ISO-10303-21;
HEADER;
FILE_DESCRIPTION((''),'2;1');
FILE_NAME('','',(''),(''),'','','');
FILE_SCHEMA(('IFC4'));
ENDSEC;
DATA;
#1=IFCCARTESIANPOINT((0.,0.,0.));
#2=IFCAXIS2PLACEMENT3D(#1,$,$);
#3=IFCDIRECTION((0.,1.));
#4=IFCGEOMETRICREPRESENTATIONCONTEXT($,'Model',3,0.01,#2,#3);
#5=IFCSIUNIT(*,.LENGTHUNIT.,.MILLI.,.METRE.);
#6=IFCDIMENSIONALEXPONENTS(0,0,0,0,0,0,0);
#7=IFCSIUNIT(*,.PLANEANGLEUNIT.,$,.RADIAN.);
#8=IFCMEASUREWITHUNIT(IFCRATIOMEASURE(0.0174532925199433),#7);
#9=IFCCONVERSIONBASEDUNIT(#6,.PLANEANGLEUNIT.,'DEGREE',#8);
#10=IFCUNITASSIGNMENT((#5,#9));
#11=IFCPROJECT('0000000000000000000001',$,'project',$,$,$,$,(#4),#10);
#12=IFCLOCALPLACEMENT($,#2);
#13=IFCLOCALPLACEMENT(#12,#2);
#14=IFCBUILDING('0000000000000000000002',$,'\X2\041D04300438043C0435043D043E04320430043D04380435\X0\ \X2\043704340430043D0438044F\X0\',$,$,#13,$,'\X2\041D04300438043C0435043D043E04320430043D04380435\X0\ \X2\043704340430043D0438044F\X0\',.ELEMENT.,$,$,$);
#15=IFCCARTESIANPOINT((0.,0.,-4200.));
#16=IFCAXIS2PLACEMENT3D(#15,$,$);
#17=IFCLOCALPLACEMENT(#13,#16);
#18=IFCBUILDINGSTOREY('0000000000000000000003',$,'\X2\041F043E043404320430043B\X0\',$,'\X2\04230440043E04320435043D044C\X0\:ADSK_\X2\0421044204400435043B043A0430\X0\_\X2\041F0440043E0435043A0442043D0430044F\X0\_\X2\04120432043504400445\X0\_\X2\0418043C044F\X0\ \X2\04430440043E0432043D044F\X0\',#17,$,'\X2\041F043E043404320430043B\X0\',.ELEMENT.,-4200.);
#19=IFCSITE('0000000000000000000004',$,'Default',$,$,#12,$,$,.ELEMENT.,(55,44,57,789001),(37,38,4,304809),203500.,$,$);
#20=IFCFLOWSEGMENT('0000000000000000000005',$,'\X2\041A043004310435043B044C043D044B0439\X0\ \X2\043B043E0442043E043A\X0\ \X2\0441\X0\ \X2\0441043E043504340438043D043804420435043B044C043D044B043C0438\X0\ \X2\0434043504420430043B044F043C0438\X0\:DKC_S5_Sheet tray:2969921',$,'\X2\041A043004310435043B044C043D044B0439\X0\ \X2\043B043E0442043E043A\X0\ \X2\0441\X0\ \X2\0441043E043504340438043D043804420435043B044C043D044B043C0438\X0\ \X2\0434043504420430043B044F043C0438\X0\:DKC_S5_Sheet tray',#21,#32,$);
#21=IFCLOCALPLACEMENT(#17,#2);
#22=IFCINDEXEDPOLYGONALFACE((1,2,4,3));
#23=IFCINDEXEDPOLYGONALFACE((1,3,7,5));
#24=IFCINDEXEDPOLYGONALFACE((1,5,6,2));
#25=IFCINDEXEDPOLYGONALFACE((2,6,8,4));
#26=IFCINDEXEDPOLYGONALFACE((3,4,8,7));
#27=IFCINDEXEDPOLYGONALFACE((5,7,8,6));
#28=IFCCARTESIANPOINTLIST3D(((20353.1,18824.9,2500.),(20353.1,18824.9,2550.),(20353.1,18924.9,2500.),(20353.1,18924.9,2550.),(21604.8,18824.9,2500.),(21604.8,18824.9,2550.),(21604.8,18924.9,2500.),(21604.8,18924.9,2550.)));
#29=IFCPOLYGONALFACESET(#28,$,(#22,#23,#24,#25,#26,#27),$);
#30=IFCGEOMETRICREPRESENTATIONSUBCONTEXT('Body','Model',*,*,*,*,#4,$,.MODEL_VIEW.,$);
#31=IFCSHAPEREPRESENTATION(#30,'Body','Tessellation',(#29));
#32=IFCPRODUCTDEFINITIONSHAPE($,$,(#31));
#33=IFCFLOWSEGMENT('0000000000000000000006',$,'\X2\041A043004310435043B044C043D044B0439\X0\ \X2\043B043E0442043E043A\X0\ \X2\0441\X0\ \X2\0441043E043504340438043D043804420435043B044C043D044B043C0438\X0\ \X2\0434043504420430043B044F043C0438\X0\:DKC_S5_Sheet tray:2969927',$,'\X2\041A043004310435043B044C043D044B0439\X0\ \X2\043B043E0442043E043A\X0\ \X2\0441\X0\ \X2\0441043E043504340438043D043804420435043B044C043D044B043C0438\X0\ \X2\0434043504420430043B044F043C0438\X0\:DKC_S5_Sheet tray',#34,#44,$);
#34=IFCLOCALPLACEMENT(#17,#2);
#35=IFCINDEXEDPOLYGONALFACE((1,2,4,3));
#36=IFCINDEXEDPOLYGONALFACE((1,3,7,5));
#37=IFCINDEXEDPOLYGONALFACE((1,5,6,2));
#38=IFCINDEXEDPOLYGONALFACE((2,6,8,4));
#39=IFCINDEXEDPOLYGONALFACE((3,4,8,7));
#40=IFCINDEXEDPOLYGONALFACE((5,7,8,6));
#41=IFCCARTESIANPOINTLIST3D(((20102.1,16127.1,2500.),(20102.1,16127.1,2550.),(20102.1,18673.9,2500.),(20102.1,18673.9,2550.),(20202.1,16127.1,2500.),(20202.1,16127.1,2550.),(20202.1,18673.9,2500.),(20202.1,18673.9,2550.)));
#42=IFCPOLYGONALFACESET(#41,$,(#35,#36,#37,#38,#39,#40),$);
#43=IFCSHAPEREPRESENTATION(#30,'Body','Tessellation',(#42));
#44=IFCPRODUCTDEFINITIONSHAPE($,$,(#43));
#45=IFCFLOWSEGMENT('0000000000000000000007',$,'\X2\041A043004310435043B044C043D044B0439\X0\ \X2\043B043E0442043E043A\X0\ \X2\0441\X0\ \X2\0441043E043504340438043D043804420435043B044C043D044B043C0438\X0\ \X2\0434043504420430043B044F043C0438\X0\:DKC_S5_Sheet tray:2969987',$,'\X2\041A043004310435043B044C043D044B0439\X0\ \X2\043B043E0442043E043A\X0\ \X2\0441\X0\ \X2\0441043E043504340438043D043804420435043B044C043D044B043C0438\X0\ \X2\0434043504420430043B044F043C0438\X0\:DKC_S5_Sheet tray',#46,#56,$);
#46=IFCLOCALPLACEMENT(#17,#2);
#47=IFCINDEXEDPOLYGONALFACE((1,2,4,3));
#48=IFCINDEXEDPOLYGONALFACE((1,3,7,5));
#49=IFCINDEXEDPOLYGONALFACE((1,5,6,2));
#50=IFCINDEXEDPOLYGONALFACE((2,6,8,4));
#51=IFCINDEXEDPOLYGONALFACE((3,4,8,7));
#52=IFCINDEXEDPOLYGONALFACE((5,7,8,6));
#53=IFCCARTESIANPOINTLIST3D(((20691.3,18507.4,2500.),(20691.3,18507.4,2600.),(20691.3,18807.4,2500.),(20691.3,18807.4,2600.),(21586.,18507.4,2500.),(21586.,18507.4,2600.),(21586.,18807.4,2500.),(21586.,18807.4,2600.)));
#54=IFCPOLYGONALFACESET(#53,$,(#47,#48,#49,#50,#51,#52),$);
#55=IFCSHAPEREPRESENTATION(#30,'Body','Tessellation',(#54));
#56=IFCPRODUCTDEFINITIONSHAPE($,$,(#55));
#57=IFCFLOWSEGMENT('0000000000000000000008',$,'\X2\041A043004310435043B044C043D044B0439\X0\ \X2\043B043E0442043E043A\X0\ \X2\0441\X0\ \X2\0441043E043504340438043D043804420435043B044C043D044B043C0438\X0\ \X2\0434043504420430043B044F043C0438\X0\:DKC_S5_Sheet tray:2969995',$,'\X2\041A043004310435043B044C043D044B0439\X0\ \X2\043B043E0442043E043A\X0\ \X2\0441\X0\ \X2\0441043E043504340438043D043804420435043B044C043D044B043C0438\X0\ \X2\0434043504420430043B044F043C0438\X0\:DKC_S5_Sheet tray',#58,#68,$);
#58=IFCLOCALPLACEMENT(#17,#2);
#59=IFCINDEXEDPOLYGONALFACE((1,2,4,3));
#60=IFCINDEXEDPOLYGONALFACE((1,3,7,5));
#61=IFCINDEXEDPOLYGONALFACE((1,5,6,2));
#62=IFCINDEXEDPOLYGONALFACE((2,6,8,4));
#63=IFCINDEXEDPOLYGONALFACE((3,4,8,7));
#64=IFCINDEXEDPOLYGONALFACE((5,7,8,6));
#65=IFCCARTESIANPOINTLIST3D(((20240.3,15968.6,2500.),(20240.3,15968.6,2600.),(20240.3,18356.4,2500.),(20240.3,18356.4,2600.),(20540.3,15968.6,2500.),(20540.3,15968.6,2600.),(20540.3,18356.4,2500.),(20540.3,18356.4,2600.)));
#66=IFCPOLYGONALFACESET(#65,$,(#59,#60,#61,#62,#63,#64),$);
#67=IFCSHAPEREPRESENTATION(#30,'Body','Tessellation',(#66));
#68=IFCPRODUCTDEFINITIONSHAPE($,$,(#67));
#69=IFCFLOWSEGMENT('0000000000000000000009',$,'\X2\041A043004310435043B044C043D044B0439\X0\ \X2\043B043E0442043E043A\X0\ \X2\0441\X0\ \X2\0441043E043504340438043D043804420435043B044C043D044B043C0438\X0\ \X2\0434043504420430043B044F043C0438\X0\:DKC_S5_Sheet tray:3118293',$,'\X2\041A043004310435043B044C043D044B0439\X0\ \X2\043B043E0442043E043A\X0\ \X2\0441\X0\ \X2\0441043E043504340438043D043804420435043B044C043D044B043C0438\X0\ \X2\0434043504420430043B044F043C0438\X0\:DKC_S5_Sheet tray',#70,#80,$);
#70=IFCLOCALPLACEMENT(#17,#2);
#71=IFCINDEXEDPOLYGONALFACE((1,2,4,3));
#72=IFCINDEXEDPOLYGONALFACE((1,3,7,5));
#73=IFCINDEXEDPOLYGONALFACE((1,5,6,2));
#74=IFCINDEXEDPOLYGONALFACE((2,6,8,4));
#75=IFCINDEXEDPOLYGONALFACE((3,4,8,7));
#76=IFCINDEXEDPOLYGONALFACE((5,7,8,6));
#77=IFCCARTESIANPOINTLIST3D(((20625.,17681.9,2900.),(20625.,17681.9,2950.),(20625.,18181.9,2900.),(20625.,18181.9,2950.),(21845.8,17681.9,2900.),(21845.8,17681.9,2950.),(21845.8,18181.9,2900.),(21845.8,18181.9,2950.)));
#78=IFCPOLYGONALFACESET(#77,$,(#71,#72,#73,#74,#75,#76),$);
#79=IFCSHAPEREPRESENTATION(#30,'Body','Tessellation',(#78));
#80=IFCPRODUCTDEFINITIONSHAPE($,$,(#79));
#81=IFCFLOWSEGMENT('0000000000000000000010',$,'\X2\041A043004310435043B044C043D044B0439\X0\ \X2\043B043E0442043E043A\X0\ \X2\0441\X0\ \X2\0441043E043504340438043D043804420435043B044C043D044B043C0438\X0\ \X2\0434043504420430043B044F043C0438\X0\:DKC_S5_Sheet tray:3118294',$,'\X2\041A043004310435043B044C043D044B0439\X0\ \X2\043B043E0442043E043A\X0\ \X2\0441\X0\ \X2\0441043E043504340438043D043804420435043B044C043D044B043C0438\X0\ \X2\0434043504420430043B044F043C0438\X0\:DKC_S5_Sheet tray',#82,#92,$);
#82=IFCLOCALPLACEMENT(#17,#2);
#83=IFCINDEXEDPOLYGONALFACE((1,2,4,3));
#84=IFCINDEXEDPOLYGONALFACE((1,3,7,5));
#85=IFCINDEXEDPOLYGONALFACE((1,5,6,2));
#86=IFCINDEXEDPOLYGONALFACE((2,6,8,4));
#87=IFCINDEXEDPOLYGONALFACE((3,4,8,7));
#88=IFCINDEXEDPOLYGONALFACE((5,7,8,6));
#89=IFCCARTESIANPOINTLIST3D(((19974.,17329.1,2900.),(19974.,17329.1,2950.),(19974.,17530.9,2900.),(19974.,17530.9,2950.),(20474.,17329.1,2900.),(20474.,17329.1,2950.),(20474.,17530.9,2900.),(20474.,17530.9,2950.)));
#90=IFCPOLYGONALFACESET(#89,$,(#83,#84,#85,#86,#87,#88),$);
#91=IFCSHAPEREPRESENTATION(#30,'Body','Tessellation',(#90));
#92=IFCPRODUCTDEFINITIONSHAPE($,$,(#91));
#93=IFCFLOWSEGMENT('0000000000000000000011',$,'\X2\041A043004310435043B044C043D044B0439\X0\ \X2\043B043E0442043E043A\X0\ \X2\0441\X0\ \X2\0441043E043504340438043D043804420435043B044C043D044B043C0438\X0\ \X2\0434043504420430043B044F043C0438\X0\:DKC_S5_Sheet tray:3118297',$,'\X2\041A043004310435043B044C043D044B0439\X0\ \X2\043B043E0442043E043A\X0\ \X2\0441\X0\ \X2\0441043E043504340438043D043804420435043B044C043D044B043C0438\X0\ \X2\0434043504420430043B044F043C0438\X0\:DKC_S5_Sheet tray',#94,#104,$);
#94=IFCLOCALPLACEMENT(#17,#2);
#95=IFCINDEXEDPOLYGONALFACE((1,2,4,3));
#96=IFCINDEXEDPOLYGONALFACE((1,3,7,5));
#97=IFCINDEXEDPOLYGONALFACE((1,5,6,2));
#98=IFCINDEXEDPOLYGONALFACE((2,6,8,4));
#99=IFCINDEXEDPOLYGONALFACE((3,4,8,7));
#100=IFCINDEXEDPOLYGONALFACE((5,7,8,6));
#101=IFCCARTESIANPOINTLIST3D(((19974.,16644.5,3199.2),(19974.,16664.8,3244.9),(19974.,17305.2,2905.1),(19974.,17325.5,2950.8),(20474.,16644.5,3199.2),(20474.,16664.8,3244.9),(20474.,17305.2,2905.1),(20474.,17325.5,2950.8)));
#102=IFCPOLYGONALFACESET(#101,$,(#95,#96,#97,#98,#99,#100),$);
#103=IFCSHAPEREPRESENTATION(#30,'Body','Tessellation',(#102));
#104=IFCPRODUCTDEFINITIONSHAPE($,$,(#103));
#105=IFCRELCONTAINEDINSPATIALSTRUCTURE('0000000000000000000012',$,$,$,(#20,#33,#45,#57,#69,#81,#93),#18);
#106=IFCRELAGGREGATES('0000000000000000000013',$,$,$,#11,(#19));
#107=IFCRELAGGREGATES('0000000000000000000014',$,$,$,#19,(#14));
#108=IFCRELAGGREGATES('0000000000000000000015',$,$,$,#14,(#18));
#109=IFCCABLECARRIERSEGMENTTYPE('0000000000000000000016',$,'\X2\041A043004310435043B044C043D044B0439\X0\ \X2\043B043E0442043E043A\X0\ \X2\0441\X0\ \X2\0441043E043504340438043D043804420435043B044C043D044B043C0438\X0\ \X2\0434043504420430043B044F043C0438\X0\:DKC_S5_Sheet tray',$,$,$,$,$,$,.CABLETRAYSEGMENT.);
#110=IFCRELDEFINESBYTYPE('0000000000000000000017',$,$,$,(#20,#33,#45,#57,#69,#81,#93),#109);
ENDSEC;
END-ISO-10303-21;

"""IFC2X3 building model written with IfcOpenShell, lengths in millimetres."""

from ifc_helpers import new_model, entity, si_unit, converted_unit, direction, frame, frame_2d, origin, origin_2d_with_axis, place, context, subcontext, project, spatial, rectangle, extrude, type_object, element, save


model = new_model("IFC2X3")

# Units and contexts
model_context = context("Model", 3, precision=0.01, world=origin(), true_north=direction((0.0, 1.0)))
body_context = subcontext(model_context, "Body", "Model", "MODEL_VIEW")
ifc_project = project(units=[si_unit("LENGTHUNIT", "METRE", prefix="MILLI"), converted_unit("PLANEANGLEUNIT", "DEGREE", entity("IfcRatioMeasure", 0.0174532925199433), si_unit("PLANEANGLEUNIT", "RADIAN"), dimensions=[0, 0, 0, 0, 0, 0, 0])], contexts=[model_context])

# Site, building, storey
site_placement = place(None, frame((0.0, 0.0, 0.0)))
site = spatial("IfcSite", under=ifc_project, at=site_placement, Name="Default", CompositionType="ELEMENT", RefLatitude=(55, 44, 57, 789001), RefLongitude=(37, 38, 4, 304809), RefElevation=203500.0)
building_placement = place(site_placement, origin())
building = spatial("IfcBuilding", under=site, at=building_placement, Name="Наименование здания", LongName="Наименование здания", CompositionType="ELEMENT")
storey_placement = place(building_placement, frame((0.0, 0.0, -4200.0)))
storey = spatial("IfcBuildingStorey", under=building, at=storey_placement, Name="Подвал", ObjectType="Уровень:ADSK_Стрелка_Проектная_Вверх_Имя уровня", LongName="Подвал", CompositionType="ELEMENT", Elevation=-4200.0)

# Flow segments
cable_carrier_segment_type = type_object("IfcCableCarrierSegmentType", Name="Кабельный лоток с соединительными деталями:DKC_S5_Sheet tray", PredefinedType="CABLETRAYSEGMENT")
flow_segment_1_placement = place(storey_placement, frame((20353.1, 18824.9, 2500.0)))
element("IfcFlowSegment", 1, at=flow_segment_1_placement, inside=storey, type_object=cable_carrier_segment_type, Name="Кабельный лоток с соединительными деталями:DKC_S5_Sheet tray:2969921", ObjectType="Кабельный лоток с соединительными деталями:DKC_S5_Sheet tray", context=body_context, shape_type="SweptSolid", body=[
    extrude(rectangle(XDim=1251.6, YDim=100.0, at=frame_2d((0.0, 0.0), x_axis=(1.0, 0.0))), frame((625.8, 50.0, 0.0), z_axis=(0.0, 0.0, 1.0), x_axis=(-1.0, 0.0, 0.0)), (0.0, 0.0, 1.0), 50.0),
])
flow_segment_2_placement = place(storey_placement, frame((20102.1, 16127.1, 2500.0)))
element("IfcFlowSegment", 2, at=flow_segment_2_placement, inside=storey, type_object=cable_carrier_segment_type, Name="Кабельный лоток с соединительными деталями:DKC_S5_Sheet tray:2969927", ObjectType="Кабельный лоток с соединительными деталями:DKC_S5_Sheet tray", context=body_context, shape_type="SweptSolid", body=[
    extrude(rectangle(XDim=2546.9, YDim=100.0, at=frame_2d((0.0, 0.0), x_axis=(1.0, 0.0))), frame((50.0, 1273.4, 0.0), z_axis=(0.0, 0.0, 1.0), x_axis=(0.0, -1.0, 0.0)), (0.0, 0.0, 1.0), 50.0),
])
flow_segment_3_placement = place(storey_placement, frame((20691.3, 18507.4, 2500.0)))
element("IfcFlowSegment", 3, at=flow_segment_3_placement, inside=storey, type_object=cable_carrier_segment_type, Name="Кабельный лоток с соединительными деталями:DKC_S5_Sheet tray:2969987", ObjectType="Кабельный лоток с соединительными деталями:DKC_S5_Sheet tray", context=body_context, shape_type="SweptSolid", body=[
    extrude(rectangle(XDim=894.7, YDim=300.0, at=origin_2d_with_axis()), frame((447.4, 150.0, 0.0), z_axis=(0.0, 0.0, 1.0), x_axis=(-1.0, 0.0, 0.0)), (0.0, 0.0, 1.0), 100.0),
])
flow_segment_4_placement = place(storey_placement, frame((20240.3, 15968.6, 2500.0)))
element("IfcFlowSegment", 4, at=flow_segment_4_placement, inside=storey, type_object=cable_carrier_segment_type, Name="Кабельный лоток с соединительными деталями:DKC_S5_Sheet tray:2969995", ObjectType="Кабельный лоток с соединительными деталями:DKC_S5_Sheet tray", context=body_context, shape_type="SweptSolid", body=[
    extrude(rectangle(XDim=2387.8, YDim=300.0, at=frame_2d((0.0, 0.0), x_axis=(1.0, 0.0))), frame((150.0, 1193.9, 0.0), z_axis=(0.0, 0.0, 1.0), x_axis=(0.0, -1.0, 0.0)), (0.0, 0.0, 1.0), 100.0),
])
flow_segment_5_placement = place(storey_placement, frame((20625.0, 17681.9, 2900.0)))
element("IfcFlowSegment", 5, at=flow_segment_5_placement, inside=storey, type_object=cable_carrier_segment_type, Name="Кабельный лоток с соединительными деталями:DKC_S5_Sheet tray:3118293", ObjectType="Кабельный лоток с соединительными деталями:DKC_S5_Sheet tray", context=body_context, shape_type="SweptSolid", body=[
    extrude(rectangle(XDim=1220.8, YDim=500.0, at=frame_2d((0.0, 0.0), x_axis=(1.0, 0.0))), frame((610.4, 250.0, 0.0), z_axis=(0.0, 0.0, 1.0), x_axis=(-1.0, 0.0, 0.0)), (0.0, 0.0, 1.0), 50.0),
])
flow_segment_6_placement = place(storey_placement, frame((19974.0, 17329.1, 2900.0)))
element("IfcFlowSegment", 6, at=flow_segment_6_placement, inside=storey, type_object=cable_carrier_segment_type, Name="Кабельный лоток с соединительными деталями:DKC_S5_Sheet tray:3118294", ObjectType="Кабельный лоток с соединительными деталями:DKC_S5_Sheet tray", context=body_context, shape_type="SweptSolid", body=[
    extrude(rectangle(XDim=201.8, YDim=500.0, at=frame_2d((0.0, 0.0), x_axis=(1.0, 0.0))), frame((250.0, 100.9, 0.0), z_axis=(0.0, 0.0, 1.0), x_axis=(0.0, -1.0, 0.0)), (0.0, 0.0, 1.0), 50.0),
])
flow_segment_7_placement = place(storey_placement, frame((19974.0, 16644.5, 2905.1)))
element("IfcFlowSegment", 7, at=flow_segment_7_placement, inside=storey, type_object=cable_carrier_segment_type, Name="Кабельный лоток с соединительными деталями:DKC_S5_Sheet tray:3118297", ObjectType="Кабельный лоток с соединительными деталями:DKC_S5_Sheet tray", context=body_context, shape_type="SweptSolid", body=[
    extrude(rectangle(XDim=50.0, YDim=723.2, at=frame_2d((0.0, 0.0), x_axis=(0.0, 1.0))), frame((0.0, 340.5, 169.9), z_axis=(1.0, 0.0, 0.0), x_axis=(0.0, 0.913545, -0.406737)), (0.0, 0.0, 1.0), 500.0),
])

save(model, "model.ifc")
